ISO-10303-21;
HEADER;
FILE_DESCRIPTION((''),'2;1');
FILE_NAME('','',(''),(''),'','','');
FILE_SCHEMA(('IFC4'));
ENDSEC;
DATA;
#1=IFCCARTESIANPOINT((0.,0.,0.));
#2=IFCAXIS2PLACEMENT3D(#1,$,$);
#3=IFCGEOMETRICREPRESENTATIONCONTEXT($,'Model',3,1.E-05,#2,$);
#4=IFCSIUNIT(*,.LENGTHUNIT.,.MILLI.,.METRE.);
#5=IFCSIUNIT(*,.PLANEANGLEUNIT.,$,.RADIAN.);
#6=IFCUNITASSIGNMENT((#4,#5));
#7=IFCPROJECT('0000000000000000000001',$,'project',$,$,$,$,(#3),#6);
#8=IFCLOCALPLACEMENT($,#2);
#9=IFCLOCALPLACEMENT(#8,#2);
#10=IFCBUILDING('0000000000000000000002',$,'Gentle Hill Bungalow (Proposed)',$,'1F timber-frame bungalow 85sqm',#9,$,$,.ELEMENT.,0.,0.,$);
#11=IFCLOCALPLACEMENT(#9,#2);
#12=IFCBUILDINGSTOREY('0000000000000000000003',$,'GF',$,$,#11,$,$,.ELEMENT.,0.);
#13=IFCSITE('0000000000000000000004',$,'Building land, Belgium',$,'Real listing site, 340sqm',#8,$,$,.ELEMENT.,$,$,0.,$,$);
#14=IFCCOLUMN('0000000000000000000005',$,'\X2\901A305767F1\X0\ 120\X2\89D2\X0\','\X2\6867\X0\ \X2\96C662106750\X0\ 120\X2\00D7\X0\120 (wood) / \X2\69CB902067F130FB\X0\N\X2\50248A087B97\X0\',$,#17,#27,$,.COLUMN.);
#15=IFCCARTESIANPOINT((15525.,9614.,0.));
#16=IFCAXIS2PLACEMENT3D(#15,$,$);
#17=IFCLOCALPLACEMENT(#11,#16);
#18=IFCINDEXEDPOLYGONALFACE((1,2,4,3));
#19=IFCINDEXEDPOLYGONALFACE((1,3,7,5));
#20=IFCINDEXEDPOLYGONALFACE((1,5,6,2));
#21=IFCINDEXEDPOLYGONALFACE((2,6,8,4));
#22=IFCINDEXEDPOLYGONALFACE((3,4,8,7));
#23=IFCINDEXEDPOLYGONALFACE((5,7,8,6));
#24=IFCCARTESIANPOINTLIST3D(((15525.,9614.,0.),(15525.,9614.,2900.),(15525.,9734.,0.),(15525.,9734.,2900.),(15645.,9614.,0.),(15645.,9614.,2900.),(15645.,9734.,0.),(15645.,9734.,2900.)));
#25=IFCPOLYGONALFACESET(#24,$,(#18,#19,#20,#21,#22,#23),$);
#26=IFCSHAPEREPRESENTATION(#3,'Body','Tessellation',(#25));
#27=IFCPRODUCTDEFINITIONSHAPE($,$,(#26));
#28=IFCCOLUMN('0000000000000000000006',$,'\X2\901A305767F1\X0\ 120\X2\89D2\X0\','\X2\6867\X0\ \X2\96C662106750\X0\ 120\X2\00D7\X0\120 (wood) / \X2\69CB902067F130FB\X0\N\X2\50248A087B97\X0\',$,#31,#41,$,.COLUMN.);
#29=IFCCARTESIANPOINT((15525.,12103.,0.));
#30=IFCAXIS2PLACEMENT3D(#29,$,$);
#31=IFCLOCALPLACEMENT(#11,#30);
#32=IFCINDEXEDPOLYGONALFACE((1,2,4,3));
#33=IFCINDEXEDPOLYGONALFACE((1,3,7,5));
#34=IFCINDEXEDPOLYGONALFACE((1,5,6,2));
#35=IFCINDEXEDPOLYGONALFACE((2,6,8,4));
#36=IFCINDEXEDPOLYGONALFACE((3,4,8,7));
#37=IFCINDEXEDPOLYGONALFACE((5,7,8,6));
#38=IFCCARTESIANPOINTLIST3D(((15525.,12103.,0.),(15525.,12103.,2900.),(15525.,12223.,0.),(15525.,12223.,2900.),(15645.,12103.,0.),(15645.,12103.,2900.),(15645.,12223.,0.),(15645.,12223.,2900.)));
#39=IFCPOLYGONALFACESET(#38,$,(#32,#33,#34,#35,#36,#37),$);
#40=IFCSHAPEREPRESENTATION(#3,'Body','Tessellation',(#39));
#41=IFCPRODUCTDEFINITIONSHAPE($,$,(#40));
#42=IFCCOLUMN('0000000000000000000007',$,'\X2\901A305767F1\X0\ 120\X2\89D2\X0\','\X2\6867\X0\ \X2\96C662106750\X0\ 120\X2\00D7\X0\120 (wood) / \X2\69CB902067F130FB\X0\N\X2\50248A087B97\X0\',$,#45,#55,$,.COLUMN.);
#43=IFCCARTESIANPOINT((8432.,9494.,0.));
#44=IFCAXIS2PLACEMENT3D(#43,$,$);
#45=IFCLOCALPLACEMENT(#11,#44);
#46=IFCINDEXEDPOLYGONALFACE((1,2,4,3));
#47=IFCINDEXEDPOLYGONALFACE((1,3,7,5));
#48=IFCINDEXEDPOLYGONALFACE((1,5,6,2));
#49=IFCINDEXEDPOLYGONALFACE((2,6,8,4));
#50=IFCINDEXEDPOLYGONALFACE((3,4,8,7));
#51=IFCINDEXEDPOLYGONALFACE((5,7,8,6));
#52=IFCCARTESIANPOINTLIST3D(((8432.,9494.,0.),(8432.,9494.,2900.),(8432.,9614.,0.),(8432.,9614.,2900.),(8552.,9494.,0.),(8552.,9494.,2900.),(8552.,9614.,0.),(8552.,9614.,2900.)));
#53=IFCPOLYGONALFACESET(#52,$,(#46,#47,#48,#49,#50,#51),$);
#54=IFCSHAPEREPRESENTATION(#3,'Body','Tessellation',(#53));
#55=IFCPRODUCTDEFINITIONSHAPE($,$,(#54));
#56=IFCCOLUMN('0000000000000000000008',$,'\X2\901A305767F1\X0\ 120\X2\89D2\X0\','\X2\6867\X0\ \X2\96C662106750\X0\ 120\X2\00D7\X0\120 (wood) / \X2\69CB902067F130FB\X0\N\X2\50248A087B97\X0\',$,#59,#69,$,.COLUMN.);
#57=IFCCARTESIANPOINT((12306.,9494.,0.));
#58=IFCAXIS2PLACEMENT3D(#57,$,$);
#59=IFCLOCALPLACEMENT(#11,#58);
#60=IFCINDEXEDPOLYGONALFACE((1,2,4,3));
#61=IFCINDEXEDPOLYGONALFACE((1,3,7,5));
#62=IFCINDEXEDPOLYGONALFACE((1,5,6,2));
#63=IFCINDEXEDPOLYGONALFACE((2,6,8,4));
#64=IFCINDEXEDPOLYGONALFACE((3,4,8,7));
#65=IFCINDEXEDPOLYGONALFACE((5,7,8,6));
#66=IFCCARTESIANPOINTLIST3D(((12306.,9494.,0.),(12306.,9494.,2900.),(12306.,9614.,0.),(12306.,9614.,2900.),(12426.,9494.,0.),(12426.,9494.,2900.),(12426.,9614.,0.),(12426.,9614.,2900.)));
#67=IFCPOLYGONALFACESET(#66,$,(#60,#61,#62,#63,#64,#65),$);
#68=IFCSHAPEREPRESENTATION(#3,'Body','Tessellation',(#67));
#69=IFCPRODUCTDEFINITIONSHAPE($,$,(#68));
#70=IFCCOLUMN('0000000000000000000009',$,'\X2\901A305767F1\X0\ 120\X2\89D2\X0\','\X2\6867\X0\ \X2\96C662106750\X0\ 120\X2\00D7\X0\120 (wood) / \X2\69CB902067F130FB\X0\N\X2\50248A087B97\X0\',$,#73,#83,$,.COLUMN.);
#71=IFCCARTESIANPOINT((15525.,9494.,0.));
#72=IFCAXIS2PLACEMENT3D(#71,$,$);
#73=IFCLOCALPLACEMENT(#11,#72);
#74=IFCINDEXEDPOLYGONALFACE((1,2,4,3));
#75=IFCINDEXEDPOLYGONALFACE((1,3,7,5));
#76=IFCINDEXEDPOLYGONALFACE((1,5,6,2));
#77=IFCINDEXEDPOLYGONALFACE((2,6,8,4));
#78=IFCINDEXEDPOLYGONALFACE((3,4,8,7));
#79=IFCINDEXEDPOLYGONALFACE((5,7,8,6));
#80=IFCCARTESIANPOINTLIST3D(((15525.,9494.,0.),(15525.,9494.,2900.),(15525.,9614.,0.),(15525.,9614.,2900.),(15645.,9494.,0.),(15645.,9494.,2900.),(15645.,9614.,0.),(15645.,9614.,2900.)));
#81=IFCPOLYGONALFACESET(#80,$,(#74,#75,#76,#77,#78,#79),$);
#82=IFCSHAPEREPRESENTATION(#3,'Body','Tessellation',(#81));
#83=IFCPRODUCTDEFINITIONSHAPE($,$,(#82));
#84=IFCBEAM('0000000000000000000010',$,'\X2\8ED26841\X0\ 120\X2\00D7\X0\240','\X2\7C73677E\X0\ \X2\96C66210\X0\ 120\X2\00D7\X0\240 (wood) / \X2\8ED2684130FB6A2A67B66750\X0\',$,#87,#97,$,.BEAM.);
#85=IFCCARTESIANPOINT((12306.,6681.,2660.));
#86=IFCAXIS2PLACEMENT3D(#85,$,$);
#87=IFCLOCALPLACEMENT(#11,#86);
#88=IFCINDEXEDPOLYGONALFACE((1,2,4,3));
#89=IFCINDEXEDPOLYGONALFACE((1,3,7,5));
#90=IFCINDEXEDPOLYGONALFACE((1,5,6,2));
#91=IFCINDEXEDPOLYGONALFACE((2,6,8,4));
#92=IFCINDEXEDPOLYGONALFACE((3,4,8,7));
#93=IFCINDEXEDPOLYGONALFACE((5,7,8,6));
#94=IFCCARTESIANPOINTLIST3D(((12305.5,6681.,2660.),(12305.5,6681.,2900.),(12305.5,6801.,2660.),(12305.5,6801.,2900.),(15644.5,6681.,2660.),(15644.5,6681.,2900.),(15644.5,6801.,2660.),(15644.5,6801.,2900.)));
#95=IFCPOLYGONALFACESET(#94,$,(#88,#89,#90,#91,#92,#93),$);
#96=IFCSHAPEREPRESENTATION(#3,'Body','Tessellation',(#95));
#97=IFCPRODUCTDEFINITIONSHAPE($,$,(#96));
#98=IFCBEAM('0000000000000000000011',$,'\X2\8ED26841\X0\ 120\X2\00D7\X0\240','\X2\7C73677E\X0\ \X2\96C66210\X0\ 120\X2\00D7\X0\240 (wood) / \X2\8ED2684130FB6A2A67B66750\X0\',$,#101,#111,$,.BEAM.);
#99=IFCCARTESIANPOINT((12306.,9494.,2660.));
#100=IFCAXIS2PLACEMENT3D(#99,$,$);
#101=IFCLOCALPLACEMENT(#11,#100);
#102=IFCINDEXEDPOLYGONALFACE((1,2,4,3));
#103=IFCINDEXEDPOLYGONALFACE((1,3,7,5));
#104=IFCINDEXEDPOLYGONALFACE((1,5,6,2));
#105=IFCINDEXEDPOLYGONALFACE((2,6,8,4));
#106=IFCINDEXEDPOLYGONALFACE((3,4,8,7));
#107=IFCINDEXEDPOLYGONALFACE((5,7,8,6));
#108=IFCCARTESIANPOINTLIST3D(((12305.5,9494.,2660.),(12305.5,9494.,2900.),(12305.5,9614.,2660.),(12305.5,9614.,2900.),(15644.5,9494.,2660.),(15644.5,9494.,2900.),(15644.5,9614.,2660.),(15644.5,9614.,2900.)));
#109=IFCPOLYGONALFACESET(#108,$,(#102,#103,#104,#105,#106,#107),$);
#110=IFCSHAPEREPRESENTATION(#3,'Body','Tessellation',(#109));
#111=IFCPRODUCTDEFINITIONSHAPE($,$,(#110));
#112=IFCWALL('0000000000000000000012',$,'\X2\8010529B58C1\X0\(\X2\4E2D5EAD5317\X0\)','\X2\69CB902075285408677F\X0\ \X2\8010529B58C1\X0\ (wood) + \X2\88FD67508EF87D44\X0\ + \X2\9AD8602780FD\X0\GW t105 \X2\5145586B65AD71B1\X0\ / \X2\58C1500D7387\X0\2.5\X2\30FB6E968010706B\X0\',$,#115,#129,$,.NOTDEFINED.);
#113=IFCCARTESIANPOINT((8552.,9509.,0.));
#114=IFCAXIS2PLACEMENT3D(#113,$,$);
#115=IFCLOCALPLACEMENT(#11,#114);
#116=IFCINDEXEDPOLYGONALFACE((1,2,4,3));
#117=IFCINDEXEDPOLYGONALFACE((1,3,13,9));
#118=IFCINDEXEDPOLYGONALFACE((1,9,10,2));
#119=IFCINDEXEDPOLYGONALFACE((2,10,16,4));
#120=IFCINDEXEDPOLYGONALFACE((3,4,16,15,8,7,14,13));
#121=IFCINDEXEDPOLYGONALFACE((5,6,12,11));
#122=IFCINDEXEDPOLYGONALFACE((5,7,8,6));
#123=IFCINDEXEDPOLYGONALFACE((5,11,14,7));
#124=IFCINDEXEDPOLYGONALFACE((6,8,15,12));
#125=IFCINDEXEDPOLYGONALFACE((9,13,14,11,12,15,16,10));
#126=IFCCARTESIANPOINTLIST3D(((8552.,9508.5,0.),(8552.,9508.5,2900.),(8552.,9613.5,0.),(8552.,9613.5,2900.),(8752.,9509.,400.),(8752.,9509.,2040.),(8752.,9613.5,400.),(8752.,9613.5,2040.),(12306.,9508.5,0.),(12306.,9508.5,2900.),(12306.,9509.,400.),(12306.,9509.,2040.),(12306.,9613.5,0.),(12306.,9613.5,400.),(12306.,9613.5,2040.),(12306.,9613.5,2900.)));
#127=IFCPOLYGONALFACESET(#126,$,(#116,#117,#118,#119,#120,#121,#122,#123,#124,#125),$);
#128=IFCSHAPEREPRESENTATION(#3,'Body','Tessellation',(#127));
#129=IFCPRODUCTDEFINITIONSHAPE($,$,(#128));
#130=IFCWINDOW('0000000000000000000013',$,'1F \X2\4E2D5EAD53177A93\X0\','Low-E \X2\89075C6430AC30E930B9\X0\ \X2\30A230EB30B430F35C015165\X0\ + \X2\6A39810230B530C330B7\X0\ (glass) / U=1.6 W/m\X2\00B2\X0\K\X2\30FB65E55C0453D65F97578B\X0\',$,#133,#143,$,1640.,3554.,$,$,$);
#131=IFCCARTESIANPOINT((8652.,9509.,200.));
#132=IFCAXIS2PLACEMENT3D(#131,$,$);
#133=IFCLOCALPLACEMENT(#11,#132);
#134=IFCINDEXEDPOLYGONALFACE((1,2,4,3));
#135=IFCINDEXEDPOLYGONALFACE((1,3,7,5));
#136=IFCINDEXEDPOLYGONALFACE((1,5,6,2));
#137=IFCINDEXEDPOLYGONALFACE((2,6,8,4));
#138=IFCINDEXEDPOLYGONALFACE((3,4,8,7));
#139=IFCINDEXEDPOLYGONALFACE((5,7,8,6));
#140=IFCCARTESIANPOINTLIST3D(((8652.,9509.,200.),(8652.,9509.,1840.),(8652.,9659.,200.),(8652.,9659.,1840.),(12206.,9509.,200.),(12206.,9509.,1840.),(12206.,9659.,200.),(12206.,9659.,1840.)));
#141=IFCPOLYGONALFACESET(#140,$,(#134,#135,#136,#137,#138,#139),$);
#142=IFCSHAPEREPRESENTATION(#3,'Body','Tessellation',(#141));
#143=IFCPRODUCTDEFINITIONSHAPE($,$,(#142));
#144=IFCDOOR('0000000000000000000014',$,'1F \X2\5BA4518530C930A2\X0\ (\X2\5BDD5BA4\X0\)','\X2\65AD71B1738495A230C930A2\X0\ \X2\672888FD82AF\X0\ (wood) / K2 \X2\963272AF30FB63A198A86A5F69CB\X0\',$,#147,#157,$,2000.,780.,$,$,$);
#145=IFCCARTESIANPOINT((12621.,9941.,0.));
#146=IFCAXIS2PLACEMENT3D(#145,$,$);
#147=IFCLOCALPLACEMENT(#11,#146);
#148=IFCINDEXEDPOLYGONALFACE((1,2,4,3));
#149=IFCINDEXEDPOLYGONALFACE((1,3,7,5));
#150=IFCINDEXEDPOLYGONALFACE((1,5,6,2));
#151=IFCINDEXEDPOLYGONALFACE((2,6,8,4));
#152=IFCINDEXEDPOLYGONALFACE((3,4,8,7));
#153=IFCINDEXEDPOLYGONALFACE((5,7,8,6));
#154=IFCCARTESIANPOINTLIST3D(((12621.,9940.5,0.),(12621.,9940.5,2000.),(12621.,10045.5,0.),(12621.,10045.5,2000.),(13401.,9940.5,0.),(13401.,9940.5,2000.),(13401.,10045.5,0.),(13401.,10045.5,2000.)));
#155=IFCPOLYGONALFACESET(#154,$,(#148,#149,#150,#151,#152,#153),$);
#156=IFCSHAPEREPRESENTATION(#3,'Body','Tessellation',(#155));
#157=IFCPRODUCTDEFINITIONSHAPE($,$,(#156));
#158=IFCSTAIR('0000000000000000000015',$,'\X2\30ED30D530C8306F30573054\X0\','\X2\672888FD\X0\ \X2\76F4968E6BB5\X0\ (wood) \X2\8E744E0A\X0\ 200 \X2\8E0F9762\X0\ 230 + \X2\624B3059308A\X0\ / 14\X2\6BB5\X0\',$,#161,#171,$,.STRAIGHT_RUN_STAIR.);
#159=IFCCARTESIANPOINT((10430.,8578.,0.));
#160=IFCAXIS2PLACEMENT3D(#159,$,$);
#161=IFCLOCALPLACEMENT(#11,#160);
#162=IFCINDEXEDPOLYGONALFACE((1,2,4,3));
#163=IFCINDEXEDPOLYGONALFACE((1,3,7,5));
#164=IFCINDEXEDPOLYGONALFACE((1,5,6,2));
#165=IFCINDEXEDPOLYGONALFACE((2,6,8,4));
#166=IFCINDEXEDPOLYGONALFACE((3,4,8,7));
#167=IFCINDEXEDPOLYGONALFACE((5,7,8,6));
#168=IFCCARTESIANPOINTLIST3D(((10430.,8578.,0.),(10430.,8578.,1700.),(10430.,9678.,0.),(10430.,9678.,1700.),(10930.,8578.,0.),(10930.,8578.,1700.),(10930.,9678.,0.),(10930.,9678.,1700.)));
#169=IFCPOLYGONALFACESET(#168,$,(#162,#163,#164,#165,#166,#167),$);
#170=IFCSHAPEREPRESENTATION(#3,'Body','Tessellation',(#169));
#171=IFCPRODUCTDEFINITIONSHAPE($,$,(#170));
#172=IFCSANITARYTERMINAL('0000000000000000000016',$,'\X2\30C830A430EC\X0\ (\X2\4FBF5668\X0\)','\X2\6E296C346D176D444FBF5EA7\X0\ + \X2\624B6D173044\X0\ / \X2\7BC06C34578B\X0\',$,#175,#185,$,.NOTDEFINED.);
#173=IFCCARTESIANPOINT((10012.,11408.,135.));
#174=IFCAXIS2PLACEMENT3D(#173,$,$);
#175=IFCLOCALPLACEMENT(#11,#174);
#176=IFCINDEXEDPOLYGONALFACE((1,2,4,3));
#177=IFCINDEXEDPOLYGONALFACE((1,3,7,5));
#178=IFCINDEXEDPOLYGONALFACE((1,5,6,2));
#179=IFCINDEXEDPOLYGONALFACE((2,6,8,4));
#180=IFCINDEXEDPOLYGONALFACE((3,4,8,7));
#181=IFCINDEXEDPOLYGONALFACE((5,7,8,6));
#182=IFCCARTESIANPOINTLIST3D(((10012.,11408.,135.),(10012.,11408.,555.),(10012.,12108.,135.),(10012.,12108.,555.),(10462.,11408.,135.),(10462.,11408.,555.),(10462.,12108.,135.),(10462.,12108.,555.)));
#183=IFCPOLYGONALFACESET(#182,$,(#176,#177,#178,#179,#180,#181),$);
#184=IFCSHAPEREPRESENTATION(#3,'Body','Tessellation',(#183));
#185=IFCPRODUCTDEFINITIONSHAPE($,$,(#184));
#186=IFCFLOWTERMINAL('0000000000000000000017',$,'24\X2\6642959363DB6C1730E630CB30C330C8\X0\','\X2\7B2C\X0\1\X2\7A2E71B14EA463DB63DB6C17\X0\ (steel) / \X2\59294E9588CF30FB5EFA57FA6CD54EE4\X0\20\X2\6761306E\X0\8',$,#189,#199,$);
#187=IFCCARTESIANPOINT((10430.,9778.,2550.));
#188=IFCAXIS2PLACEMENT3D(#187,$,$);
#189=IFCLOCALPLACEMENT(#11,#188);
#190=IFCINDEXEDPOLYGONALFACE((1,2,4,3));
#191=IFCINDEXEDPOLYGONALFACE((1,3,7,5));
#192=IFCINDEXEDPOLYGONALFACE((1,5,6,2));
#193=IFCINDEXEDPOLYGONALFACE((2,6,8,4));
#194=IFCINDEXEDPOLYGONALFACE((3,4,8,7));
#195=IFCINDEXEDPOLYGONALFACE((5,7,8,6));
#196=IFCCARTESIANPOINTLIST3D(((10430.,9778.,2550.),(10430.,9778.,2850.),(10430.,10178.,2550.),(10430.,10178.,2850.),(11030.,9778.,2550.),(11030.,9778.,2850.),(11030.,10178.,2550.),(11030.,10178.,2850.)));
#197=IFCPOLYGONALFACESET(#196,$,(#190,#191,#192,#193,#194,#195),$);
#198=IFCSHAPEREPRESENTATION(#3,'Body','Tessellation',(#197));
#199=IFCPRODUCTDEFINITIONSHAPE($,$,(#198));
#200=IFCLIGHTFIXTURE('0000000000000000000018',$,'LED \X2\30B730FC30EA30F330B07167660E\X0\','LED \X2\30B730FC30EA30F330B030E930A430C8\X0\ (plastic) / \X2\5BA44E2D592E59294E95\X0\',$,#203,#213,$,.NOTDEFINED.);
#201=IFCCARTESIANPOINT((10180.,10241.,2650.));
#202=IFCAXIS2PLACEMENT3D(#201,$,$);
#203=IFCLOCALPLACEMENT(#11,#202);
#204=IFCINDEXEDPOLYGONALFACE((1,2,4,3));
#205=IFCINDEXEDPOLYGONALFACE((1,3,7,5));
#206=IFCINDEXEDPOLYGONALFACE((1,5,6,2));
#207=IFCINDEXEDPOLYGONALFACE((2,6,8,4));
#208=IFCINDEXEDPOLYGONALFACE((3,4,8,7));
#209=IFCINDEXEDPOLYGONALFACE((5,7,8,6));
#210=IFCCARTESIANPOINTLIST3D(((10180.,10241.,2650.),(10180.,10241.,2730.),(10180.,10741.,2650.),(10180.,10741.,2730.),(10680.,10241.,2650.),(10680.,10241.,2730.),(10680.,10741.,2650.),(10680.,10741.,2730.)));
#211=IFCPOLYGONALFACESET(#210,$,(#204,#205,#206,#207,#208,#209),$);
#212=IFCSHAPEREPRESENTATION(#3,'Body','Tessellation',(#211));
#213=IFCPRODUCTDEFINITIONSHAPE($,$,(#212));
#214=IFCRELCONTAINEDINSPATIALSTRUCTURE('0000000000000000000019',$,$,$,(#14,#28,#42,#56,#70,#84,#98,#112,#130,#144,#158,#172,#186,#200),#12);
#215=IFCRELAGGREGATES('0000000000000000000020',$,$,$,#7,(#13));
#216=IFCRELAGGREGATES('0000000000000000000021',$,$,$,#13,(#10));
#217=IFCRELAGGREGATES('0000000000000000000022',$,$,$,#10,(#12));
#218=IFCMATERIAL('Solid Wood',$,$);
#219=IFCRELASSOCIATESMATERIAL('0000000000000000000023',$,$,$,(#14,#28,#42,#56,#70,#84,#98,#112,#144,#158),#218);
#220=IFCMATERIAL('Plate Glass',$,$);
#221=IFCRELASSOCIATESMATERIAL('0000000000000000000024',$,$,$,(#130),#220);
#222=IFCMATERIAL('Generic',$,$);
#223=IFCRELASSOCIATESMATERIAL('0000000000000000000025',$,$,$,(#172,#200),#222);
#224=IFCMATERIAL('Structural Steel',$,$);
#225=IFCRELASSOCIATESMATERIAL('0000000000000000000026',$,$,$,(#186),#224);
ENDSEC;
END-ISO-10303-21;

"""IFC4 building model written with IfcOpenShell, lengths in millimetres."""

from ifc_helpers import new_model, si_unit, frame, frame_2d, origin, place, context, project, spatial, rectangle, extrude, material, element, fill, save


model = new_model("IFC4")

# Units and contexts
model_context = context("Model", 3, precision=1e-05, world=origin())
ifc_project = project(units=[si_unit("LENGTHUNIT", "METRE", prefix="MILLI"), si_unit("PLANEANGLEUNIT", "RADIAN")], contexts=[model_context])

# Site, building, storey
site_placement = place(None, origin())
site = spatial("IfcSite", under=ifc_project, at=site_placement, Name="Building land, Belgium", ObjectType="Real listing site, 340sqm", CompositionType="ELEMENT", RefElevation=0.0)
building_placement = place(site_placement, origin())
building = spatial("IfcBuilding", under=site, at=building_placement, Name="Gentle Hill Bungalow (Proposed)", ObjectType="1F timber-frame bungalow 85sqm", CompositionType="ELEMENT", ElevationOfRefHeight=0.0, ElevationOfTerrain=0.0)
storey_placement = place(building_placement, origin())
storey = spatial("IfcBuildingStorey", under=building, at=storey_placement, Name="GF", CompositionType="ELEMENT", Elevation=0.0)

# Columns
ifc_material_1 = material(Name="Solid Wood")
column_1_placement = place(storey_placement, frame((15525.0, 9614.0, 0.0)))
element("IfcColumn", 1, at=column_1_placement, inside=storey, material=ifc_material_1, Name="通し柱 120角", Description="桧 集成材 120×120 (wood) / 構造柱・N値計算", PredefinedType="COLUMN", context=model_context, shape_type="SweptSolid", body=[
    extrude(rectangle(XDim=120.0, YDim=120.0, at=frame_2d((60.0, 60.0))), frame((15525.0, 9614.0, 0.0)), (0.0, 0.0, 1.0), 2900.0),
])
column_2_placement = place(storey_placement, frame((15525.0, 12103.0, 0.0)))
element("IfcColumn", 2, at=column_2_placement, inside=storey, material=ifc_material_1, Name="通し柱 120角", Description="桧 集成材 120×120 (wood) / 構造柱・N値計算", PredefinedType="COLUMN", context=model_context, shape_type="SweptSolid", body=[
    extrude(rectangle(XDim=120.0, YDim=120.0, at=frame_2d((60.0, 60.0))), frame((15525.0, 12103.0, 0.0)), (0.0, 0.0, 1.0), 2900.0),
])
column_3_placement = place(storey_placement, frame((8432.0, 9494.0, 0.0)))
element("IfcColumn", 3, at=column_3_placement, inside=storey, material=ifc_material_1, Name="通し柱 120角", Description="桧 集成材 120×120 (wood) / 構造柱・N値計算", PredefinedType="COLUMN", context=model_context, shape_type="SweptSolid", body=[
    extrude(rectangle(XDim=120.0, YDim=120.0, at=frame_2d((60.0, 60.0))), frame((8432.0, 9494.0, 0.0)), (0.0, 0.0, 1.0), 2900.0),
])
column_4_placement = place(storey_placement, frame((12306.0, 9494.0, 0.0)))
element("IfcColumn", 4, at=column_4_placement, inside=storey, material=ifc_material_1, Name="通し柱 120角", Description="桧 集成材 120×120 (wood) / 構造柱・N値計算", PredefinedType="COLUMN", context=model_context, shape_type="SweptSolid", body=[
    extrude(rectangle(XDim=120.0, YDim=120.0, at=frame_2d((60.0, 60.0))), frame((12306.0, 9494.0, 0.0)), (0.0, 0.0, 1.0), 2900.0),
])
column_5_placement = place(storey_placement, frame((15525.0, 9494.0, 0.0)))
element("IfcColumn", 5, at=column_5_placement, inside=storey, material=ifc_material_1, Name="通し柱 120角", Description="桧 集成材 120×120 (wood) / 構造柱・N値計算", PredefinedType="COLUMN", context=model_context, shape_type="SweptSolid", body=[
    extrude(rectangle(XDim=120.0, YDim=120.0, at=frame_2d((60.0, 60.0))), frame((15525.0, 9494.0, 0.0)), (0.0, 0.0, 1.0), 2900.0),
])

# Beams
beam_1_placement = place(storey_placement, frame((12306.0, 6681.0, 2660.0)))
element("IfcBeam", 6, at=beam_1_placement, inside=storey, material=ifc_material_1, Name="軒桁 120×240", Description="米松 集成 120×240 (wood) / 軒桁・横架材", PredefinedType="BEAM", context=model_context, shape_type="SweptSolid", body=[
    extrude(rectangle(XDim=3339.0, YDim=120.0, at=frame_2d((1669.0, 60.0))), frame((12306.0, 6681.0, 2660.0)), (0.0, 0.0, 1.0), 240.0),
])
beam_2_placement = place(storey_placement, frame((12306.0, 9494.0, 2660.0)))
element("IfcBeam", 7, at=beam_2_placement, inside=storey, material=ifc_material_1, Name="軒桁 120×240", Description="米松 集成 120×240 (wood) / 軒桁・横架材", PredefinedType="BEAM", context=model_context, shape_type="SweptSolid", body=[
    extrude(rectangle(XDim=3339.0, YDim=120.0, at=frame_2d((1669.0, 60.0))), frame((12306.0, 9494.0, 2660.0)), (0.0, 0.0, 1.0), 240.0),
])

# Wall, opening, window
wall_1_placement = place(storey_placement, frame((8552.0, 9509.0, 0.0)))
wall_1 = element("IfcWall", 8, at=wall_1_placement, inside=storey, material=ifc_material_1, Name="耐力壁(中庭北)", Description="構造用合板 耐力壁 (wood) + 製材軸組 + 高性能GW t105 充填断熱 / 壁倍率2.5・準耐火", PredefinedType="NOTDEFINED", context=model_context, shape_type="SweptSolid", body=[
    extrude(rectangle(XDim=3754.0, YDim=105.0, at=frame_2d((1877.0, 52.0))), frame((8552.0, 9509.0, 0.0)), (0.0, 0.0, 1.0), 2900.0),
])
opening_placement = place(storey_placement, frame((8652.0, 9509.0, 200.0)))
opening = element("IfcOpeningElement", 9, at=opening_placement, cuts=wall_1, PredefinedType="NOTDEFINED", context=model_context, shape_type="SweptSolid", body=[
    extrude(rectangle(XDim=3554.0, YDim=150.0, at=frame_2d((1777.0, 75.0))), frame((8652.0, 9509.0, 200.0)), (0.0, 0.0, 1.0), 1640.0),
])
ifc_material_2 = material(Name="Plate Glass")
window_placement = place(storey_placement, frame((8652.0, 9509.0, 200.0)))
window = element("IfcWindow", 10, at=window_placement, inside=storey, material=ifc_material_2, Name="1F 中庭北窓", Description="Low-E 複層ガラス アルゴン封入 + 樹脂サッシ (glass) / U=1.6 W/m²K・日射取得型", OverallHeight=1640.0, OverallWidth=3554.0, context=model_context, shape_type="SweptSolid", body=[
    extrude(rectangle(XDim=3554.0, YDim=150.0, at=frame_2d((1777.0, 75.0))), frame((8652.0, 9509.0, 200.0)), (0.0, 0.0, 1.0), 1640.0),
])
fill(opening, window)

# Door
door_placement = place(storey_placement, frame((12621.0, 9941.0, 0.0)))
element("IfcDoor", 11, at=door_placement, inside=storey, material=ifc_material_1, Name="1F 室内ドア (寝室)", Description="断熱玄関ドア 木製芯 (wood) / K2 防犯・採風機構", OverallHeight=2000.0, OverallWidth=780.0, context=model_context, shape_type="SweptSolid", body=[
    extrude(rectangle(XDim=780.0, YDim=105.0, at=frame_2d((390.0, 52.0))), frame((12621.0, 9941.0, 0.0)), (0.0, 0.0, 1.0), 2000.0),
])

# Stair
stair_placement = place(storey_placement, frame((10430.0, 8578.0, 0.0)))
element("IfcStair", 12, at=stair_placement, inside=storey, material=ifc_material_1, Name="ロフトはしご", Description="木製 直階段 (wood) 蹴上 200 踏面 230 + 手すり / 14段", PredefinedType="STRAIGHT_RUN_STAIR", context=model_context, shape_type="SweptSolid", body=[
    extrude(rectangle(XDim=500.0, YDim=1100.0, at=frame_2d((250.0, 550.0))), frame((10430.0, 8578.0, 0.0)), (0.0, 0.0, 1.0), 1700.0),
])

# Shared definitions
ifc_material_3 = material(Name="Generic")

# Sanitary terminal
sanitary_terminal_placement = place(storey_placement, frame((10012.0, 11408.0, 135.0)))
element("IfcSanitaryTerminal", 13, at=sanitary_terminal_placement, inside=storey, material=ifc_material_3, Name="トイレ (便器)", Description="温水洗浄便座 + 手洗い / 節水型", PredefinedType="NOTDEFINED", context=model_context, shape_type="SweptSolid", body=[
    extrude(rectangle(XDim=450.0, YDim=700.0, at=frame_2d((225.0, 350.0))), frame((10012.0, 11408.0, 135.0)), (0.0, 0.0, 1.0), 420.0),
])

# Flow terminal
ifc_material_4 = material(Name="Structural Steel")
flow_terminal_placement = place(storey_placement, frame((10430.0, 9778.0, 2550.0)))
element("IfcFlowTerminal", 14, at=flow_terminal_placement, inside=storey, material=ifc_material_4, Name="24時間換気ユニット", Description="第1種熱交換換気 (steel) / 天井裏・建基法令20条の8", context=model_context, shape_type="SweptSolid", body=[
    extrude(rectangle(XDim=600.0, YDim=400.0, at=frame_2d((300.0, 200.0))), frame((10430.0, 9778.0, 2550.0)), (0.0, 0.0, 1.0), 300.0),
])

# Light fixture
light_fixture_1_placement = place(storey_placement, frame((10180.0, 10241.0, 2650.0)))
element("IfcLightFixture", 15, at=light_fixture_1_placement, inside=storey, material=ifc_material_3, Name="LED シーリング照明", Description="LED シーリングライト (plastic) / 室中央天井", PredefinedType="NOTDEFINED", context=model_context, shape_type="SweptSolid", body=[
    extrude(rectangle(XDim=500.0, YDim=500.0, at=frame_2d((250.0, 250.0))), frame((10180.0, 10241.0, 2650.0)), (0.0, 0.0, 1.0), 80.0),
])

save(model, "model.ifc")
